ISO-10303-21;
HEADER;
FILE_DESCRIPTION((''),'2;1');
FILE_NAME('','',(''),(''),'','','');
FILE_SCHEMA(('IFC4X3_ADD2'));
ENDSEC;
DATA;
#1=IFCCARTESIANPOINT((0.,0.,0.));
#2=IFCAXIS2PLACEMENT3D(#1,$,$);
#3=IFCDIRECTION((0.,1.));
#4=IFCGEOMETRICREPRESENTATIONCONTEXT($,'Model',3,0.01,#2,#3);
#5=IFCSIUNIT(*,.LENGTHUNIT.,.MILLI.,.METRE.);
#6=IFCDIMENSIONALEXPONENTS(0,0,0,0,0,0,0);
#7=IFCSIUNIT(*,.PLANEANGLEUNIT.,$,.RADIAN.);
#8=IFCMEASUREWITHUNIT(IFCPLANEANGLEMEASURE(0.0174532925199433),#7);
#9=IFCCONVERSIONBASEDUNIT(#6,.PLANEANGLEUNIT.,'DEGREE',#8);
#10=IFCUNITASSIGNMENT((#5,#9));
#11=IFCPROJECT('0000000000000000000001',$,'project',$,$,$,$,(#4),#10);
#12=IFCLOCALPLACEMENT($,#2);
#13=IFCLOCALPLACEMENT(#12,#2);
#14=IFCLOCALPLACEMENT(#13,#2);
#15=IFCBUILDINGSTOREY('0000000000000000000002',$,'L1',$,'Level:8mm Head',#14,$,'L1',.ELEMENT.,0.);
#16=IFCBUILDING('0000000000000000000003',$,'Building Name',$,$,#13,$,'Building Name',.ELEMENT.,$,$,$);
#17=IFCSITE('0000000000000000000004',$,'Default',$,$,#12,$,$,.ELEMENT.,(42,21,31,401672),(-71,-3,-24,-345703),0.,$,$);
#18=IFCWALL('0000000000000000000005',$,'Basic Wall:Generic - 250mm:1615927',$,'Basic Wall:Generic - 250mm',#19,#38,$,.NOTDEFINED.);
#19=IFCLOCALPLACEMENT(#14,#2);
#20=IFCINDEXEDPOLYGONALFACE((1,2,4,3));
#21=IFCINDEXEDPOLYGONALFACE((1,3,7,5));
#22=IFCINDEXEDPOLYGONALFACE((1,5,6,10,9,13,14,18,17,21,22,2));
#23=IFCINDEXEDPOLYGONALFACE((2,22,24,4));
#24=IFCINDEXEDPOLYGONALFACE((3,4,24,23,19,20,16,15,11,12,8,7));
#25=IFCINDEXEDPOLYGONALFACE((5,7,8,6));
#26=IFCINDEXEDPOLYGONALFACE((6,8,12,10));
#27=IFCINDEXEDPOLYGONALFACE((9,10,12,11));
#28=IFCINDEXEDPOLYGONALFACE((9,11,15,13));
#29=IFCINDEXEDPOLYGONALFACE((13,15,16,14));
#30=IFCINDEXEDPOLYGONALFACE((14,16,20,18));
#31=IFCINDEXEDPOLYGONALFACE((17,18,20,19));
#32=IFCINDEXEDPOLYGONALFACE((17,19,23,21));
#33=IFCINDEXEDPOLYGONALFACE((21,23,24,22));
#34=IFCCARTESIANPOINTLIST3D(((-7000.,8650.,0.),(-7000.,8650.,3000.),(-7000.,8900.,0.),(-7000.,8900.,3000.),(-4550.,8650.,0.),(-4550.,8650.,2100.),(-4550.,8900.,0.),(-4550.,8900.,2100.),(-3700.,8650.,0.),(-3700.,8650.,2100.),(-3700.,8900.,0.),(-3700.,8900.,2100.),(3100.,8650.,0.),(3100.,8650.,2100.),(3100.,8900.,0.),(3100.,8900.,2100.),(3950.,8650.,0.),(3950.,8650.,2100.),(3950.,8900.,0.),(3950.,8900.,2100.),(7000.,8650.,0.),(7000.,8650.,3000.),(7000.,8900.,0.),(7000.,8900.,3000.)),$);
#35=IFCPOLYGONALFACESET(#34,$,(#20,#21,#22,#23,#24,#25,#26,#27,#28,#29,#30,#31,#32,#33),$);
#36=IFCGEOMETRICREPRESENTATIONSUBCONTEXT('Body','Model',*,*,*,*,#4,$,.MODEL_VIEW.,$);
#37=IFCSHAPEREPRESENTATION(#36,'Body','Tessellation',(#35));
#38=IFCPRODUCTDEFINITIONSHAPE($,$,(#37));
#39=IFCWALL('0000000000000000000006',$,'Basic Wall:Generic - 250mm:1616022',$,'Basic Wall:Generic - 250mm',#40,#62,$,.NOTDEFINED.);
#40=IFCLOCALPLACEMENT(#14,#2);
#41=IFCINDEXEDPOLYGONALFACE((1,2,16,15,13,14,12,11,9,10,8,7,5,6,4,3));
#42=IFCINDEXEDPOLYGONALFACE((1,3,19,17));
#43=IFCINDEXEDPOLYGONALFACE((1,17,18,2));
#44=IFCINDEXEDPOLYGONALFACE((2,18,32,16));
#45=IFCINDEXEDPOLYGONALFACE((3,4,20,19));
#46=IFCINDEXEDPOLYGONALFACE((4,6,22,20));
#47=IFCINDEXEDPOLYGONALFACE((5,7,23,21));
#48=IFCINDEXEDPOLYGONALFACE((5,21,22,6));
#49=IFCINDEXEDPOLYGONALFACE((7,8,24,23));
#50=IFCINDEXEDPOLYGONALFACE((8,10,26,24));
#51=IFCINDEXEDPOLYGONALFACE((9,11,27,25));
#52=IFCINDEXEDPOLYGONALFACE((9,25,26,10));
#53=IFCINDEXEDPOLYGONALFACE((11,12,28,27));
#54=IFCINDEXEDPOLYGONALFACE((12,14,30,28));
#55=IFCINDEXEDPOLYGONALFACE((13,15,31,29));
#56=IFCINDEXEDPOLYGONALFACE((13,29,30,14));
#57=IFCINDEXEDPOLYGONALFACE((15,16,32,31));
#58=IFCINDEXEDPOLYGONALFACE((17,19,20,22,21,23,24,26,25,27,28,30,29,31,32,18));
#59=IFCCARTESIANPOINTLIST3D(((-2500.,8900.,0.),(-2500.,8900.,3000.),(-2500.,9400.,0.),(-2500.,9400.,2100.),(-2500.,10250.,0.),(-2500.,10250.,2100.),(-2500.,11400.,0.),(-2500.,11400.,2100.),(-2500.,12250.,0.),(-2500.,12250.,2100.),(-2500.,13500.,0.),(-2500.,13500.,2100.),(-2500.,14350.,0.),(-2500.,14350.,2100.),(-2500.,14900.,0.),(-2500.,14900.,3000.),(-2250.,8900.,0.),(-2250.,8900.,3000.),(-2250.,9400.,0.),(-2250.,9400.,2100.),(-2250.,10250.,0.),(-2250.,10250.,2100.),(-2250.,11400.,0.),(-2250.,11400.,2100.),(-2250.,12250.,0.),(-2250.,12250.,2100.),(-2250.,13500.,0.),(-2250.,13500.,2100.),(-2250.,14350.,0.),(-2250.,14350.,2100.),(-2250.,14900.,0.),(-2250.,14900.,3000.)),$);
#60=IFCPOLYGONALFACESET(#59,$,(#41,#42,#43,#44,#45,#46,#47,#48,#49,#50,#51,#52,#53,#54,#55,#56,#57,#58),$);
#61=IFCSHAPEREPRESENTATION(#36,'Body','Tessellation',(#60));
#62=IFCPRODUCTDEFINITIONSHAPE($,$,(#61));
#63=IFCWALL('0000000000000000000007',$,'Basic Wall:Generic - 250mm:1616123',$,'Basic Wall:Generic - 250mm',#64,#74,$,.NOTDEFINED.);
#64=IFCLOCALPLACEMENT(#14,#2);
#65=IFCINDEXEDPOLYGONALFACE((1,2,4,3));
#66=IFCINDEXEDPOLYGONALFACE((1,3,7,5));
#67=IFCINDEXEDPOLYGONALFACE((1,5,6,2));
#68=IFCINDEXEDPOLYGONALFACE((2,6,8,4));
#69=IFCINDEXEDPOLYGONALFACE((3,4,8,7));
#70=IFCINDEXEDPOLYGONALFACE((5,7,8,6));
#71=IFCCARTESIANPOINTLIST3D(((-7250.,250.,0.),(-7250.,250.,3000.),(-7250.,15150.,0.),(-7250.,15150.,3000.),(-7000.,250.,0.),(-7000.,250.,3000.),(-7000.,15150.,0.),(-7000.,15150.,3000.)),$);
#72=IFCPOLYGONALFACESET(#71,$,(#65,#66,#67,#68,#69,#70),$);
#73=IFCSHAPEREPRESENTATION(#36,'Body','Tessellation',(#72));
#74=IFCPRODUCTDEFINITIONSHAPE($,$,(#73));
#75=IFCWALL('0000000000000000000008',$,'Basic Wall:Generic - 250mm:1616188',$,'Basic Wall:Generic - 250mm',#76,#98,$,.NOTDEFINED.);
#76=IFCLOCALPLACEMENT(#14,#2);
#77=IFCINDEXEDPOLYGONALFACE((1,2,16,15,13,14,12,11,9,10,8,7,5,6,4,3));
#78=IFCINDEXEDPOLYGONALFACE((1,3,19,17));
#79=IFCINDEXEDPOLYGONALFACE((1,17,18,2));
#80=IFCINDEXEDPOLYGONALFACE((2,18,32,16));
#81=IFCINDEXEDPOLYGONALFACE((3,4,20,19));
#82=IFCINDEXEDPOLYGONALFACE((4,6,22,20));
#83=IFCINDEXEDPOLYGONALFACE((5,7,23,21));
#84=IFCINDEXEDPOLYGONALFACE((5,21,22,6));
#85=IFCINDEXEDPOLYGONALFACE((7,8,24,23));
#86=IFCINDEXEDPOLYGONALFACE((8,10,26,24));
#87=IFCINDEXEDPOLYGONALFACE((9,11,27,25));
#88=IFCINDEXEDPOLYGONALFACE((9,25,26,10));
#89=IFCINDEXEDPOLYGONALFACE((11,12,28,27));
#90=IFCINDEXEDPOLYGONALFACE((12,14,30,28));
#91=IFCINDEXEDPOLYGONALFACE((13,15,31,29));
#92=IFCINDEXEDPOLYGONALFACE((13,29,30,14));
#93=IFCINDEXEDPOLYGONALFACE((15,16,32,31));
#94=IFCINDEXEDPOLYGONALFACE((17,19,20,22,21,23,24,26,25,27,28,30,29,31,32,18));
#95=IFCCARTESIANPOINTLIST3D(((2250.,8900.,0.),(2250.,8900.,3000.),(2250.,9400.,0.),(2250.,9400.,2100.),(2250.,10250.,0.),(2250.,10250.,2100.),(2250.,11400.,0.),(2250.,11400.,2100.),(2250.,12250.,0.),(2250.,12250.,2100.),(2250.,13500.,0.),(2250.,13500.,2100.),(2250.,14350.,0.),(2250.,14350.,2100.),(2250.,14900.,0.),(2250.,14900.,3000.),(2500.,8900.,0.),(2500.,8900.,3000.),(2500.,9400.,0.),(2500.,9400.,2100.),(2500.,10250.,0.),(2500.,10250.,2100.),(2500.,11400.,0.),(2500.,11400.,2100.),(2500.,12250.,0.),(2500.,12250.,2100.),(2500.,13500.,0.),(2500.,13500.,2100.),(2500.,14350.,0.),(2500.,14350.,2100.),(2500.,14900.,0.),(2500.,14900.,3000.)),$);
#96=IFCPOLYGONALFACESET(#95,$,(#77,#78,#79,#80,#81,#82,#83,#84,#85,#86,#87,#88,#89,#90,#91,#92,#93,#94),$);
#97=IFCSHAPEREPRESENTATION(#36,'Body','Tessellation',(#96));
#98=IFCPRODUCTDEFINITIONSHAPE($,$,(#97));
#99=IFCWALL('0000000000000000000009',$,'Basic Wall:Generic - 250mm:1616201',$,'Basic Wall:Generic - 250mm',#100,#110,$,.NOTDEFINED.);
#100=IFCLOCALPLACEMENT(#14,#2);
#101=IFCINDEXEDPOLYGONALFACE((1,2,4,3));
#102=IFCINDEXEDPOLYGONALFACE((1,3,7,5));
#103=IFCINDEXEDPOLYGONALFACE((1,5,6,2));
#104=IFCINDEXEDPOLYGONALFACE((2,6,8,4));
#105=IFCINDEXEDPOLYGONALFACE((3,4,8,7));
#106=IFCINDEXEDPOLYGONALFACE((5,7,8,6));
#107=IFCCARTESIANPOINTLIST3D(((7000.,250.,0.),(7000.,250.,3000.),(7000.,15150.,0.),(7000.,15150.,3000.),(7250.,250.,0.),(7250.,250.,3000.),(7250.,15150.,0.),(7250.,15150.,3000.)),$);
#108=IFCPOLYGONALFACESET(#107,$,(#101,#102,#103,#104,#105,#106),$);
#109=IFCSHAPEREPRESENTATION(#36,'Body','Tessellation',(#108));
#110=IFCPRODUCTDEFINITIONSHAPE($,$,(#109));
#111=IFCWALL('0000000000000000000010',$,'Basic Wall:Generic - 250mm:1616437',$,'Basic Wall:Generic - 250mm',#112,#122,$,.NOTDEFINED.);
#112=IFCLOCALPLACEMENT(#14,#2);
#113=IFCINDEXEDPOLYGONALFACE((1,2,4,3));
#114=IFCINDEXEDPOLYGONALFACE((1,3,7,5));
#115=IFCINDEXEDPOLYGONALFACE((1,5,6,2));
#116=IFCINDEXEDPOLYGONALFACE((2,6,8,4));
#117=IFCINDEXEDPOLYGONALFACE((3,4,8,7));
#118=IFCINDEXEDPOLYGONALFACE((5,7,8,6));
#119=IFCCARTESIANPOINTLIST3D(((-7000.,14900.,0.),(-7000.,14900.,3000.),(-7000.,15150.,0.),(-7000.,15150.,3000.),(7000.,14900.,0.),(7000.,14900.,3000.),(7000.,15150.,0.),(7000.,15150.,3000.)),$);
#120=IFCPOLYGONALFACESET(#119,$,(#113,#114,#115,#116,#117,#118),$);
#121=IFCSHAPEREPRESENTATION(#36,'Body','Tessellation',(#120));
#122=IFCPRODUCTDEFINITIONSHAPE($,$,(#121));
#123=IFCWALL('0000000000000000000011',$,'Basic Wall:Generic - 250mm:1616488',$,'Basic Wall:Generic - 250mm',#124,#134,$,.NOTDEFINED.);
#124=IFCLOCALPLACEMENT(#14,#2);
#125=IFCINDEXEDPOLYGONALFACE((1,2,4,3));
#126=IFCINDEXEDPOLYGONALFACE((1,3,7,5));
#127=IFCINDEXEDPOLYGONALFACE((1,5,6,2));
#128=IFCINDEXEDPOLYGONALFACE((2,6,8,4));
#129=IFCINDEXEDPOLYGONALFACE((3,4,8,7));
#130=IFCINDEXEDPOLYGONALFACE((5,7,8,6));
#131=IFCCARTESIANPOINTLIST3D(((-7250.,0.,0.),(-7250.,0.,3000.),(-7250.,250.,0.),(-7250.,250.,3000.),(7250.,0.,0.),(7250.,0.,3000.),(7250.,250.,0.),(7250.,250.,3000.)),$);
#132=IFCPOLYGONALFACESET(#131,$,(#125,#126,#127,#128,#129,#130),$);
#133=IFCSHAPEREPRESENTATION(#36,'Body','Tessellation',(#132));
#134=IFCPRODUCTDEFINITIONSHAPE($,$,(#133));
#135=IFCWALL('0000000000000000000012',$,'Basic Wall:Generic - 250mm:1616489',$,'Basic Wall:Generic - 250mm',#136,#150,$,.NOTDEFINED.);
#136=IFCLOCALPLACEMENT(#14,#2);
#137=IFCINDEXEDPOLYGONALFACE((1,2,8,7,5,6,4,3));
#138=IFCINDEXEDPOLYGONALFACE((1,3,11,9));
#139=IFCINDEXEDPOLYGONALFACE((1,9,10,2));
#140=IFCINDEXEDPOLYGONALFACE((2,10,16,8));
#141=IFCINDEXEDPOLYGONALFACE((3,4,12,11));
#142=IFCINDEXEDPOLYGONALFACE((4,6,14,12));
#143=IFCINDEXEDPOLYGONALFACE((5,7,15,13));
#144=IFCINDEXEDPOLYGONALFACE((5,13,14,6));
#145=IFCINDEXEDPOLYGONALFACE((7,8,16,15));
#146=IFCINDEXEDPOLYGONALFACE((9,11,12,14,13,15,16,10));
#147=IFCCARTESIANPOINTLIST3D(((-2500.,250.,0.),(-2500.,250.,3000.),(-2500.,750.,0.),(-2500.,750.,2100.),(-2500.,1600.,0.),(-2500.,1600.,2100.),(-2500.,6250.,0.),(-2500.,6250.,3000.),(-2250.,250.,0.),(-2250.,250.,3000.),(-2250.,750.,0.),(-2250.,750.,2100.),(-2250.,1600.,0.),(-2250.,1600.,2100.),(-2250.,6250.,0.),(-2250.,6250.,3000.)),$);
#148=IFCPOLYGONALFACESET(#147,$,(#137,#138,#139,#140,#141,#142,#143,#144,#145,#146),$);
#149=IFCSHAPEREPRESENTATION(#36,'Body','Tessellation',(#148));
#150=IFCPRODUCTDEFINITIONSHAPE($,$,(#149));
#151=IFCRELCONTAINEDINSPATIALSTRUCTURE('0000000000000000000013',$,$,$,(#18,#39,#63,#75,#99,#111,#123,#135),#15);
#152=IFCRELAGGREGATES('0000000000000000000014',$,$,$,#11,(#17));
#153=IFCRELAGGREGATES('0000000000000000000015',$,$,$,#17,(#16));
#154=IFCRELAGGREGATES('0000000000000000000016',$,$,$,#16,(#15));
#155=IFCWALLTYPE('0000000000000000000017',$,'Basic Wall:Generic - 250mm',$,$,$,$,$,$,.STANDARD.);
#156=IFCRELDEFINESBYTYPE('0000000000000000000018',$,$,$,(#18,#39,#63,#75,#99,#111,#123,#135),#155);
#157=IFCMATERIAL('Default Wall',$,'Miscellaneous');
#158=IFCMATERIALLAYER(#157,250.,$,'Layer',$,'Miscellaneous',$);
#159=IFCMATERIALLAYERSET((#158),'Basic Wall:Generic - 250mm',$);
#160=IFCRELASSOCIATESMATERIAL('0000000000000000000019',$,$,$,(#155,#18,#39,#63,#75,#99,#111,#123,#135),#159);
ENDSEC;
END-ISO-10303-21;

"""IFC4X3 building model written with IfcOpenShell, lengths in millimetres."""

from ifc_helpers import new_model, entity, si_unit, converted_unit, direction, frame, frame_2d, origin, place, context, subcontext, project, spatial, rectangle, extrude, material, layer, layer_set, type_object, element, save


model = new_model("IFC4X3")

# Units and contexts
model_context = context("Model", 3, precision=0.01, world=origin(), true_north=direction((0.0, 1.0)))
body_context = subcontext(model_context, "Body", "Model", "MODEL_VIEW")
ifc_project = project(units=[si_unit("LENGTHUNIT", "METRE", prefix="MILLI"), converted_unit("PLANEANGLEUNIT", "DEGREE", entity("IfcPlaneAngleMeasure", 0.0174532925199433), si_unit("PLANEANGLEUNIT", "RADIAN"), dimensions=[0, 0, 0, 0, 0, 0, 0])], contexts=[model_context])

# Site, building, storey
site_placement = place(None, origin())
site = spatial("IfcSite", under=ifc_project, at=site_placement, Name="Default", CompositionType="ELEMENT", RefLatitude=(42, 21, 31, 401672), RefLongitude=(-71, -3, -24, -345703), RefElevation=0.0)
building_placement = place(site_placement, origin())
building = spatial("IfcBuilding", under=site, at=building_placement, Name="Building Name", LongName="Building Name", CompositionType="ELEMENT")
storey_placement = place(building_placement, origin())
storey = spatial("IfcBuildingStorey", under=building, at=storey_placement, Name="L1", ObjectType="Level:8mm Head", LongName="L1", CompositionType="ELEMENT", Elevation=0.0)

# Walls, openings
ifc_material = material(Name="Default Wall", Category="Miscellaneous")
ifc_layer_1 = layer(ifc_material, 250.0, Name="Layer", Category="Miscellaneous")
ifc_layer_set_1 = layer_set([ifc_layer_1], Name="Basic Wall:Generic - 250mm")
wall_type_1 = type_object("IfcWallType", Name="Basic Wall:Generic - 250mm", PredefinedType="STANDARD", material=ifc_layer_set_1)
wall_1_placement = place(storey_placement, frame((-7000.0, 8775.0, 0.0)))
wall_1 = element("IfcWall", 1, at=wall_1_placement, inside=storey, type_object=wall_type_1, material=ifc_layer_set_1, Name="Basic Wall:Generic - 250mm:1615927", ObjectType="Basic Wall:Generic - 250mm", PredefinedType="NOTDEFINED", context=body_context, shape_type="SweptSolid", body=[
    extrude(rectangle(XDim=14000.0, YDim=250.0, at=frame_2d((7000.0, 0.0), x_axis=(1.0, 0.0))), origin(), (0.0, 0.0, 1.0), 3000.0),
])
opening_1_placement = place(wall_1_placement, frame((2450.0, -125.0, 0.0)))
element("IfcOpeningElement", 2, at=opening_1_placement, cuts=wall_1, PredefinedType="OPENING", context=body_context, shape_type="SweptSolid", body=[
    extrude(rectangle(XDim=2100.0, YDim=850.0, at=frame_2d((1050.0, 425.0), x_axis=(1.0, 0.0))), frame((0.0, 0.0, 0.0), z_axis=(0.0, 1.0, 0.0), x_axis=(0.0, 0.0, 1.0)), (0.0, 0.0, 1.0), 250.0),
])
opening_2_placement = place(wall_1_placement, frame((10100.0, -125.0, 0.0)))
element("IfcOpeningElement", 3, at=opening_2_placement, cuts=wall_1, PredefinedType="OPENING", context=body_context, shape_type="SweptSolid", body=[
    extrude(rectangle(XDim=2100.0, YDim=850.0, at=frame_2d((1050.0, 425.0), x_axis=(1.0, 0.0))), frame((0.0, 0.0, 0.0), z_axis=(0.0, 1.0, 0.0), x_axis=(0.0, 0.0, 1.0)), (0.0, 0.0, 1.0), 250.0),
])
wall_2_placement = place(storey_placement, frame((-2375.0, 8900.0, 0.0), z_axis=(0.0, 0.0, 1.0), x_axis=(0.0, 1.0, 0.0)))
wall_2 = element("IfcWall", 4, at=wall_2_placement, inside=storey, type_object=wall_type_1, material=ifc_layer_set_1, Name="Basic Wall:Generic - 250mm:1616022", ObjectType="Basic Wall:Generic - 250mm", PredefinedType="NOTDEFINED", context=body_context, shape_type="SweptSolid", body=[
    extrude(rectangle(XDim=6000.0, YDim=250.0, at=frame_2d((3000.0, 0.0), x_axis=(1.0, 0.0))), origin(), (0.0, 0.0, 1.0), 3000.0),
])
opening_3_placement = place(wall_2_placement, frame((1350.0, 125.0, 0.0)))
element("IfcOpeningElement", 5, at=opening_3_placement, cuts=wall_2, PredefinedType="OPENING", context=body_context, shape_type="SweptSolid", body=[
    extrude(rectangle(XDim=2100.0, YDim=850.0, at=frame_2d((1050.0, 425.0), x_axis=(1.0, 0.0))), frame((0.0, 0.0, 0.0), z_axis=(0.0, -1.0, 0.0), x_axis=(0.0, 0.0, 1.0)), (0.0, 0.0, 1.0), 250.0),
])
opening_4_placement = place(wall_2_placement, frame((3350.0, 125.0, 0.0)))
element("IfcOpeningElement", 6, at=opening_4_placement, cuts=wall_2, PredefinedType="OPENING", context=body_context, shape_type="SweptSolid", body=[
    extrude(rectangle(XDim=2100.0, YDim=850.0, at=frame_2d((1050.0, 425.0), x_axis=(1.0, 0.0))), frame((0.0, 0.0, 0.0), z_axis=(0.0, -1.0, 0.0), x_axis=(0.0, 0.0, 1.0)), (0.0, 0.0, 1.0), 250.0),
])
opening_5_placement = place(wall_2_placement, frame((5450.0, 125.0, 0.0)))
element("IfcOpeningElement", 7, at=opening_5_placement, cuts=wall_2, PredefinedType="OPENING", context=body_context, shape_type="SweptSolid", body=[
    extrude(rectangle(XDim=2100.0, YDim=850.0, at=frame_2d((1050.0, 425.0), x_axis=(1.0, 0.0))), frame((0.0, 0.0, 0.0), z_axis=(0.0, -1.0, 0.0), x_axis=(0.0, 0.0, 1.0)), (0.0, 0.0, 1.0), 250.0),
])

# Wall
wall_3_placement = place(storey_placement, frame((-7125.0, 15150.0, 0.0), z_axis=(0.0, 0.0, 1.0), x_axis=(0.0, -1.0, 0.0)))
element("IfcWall", 8, at=wall_3_placement, inside=storey, type_object=wall_type_1, material=ifc_layer_set_1, Name="Basic Wall:Generic - 250mm:1616123", ObjectType="Basic Wall:Generic - 250mm", PredefinedType="NOTDEFINED", context=body_context, shape_type="SweptSolid", body=[
    extrude(rectangle(XDim=14900.0, YDim=250.0, at=frame_2d((7450.0, 0.0), x_axis=(-1.0, 0.0))), origin(), (0.0, 0.0, 1.0), 3000.0),
])

# Wall, openings
wall_4_placement = place(storey_placement, frame((2375.0, 8900.0, 0.0), z_axis=(0.0, 0.0, 1.0), x_axis=(0.0, 1.0, 0.0)))
wall_4 = element("IfcWall", 9, at=wall_4_placement, inside=storey, type_object=wall_type_1, material=ifc_layer_set_1, Name="Basic Wall:Generic - 250mm:1616188", ObjectType="Basic Wall:Generic - 250mm", PredefinedType="NOTDEFINED", context=body_context, shape_type="SweptSolid", body=[
    extrude(rectangle(XDim=6000.0, YDim=250.0, at=frame_2d((3000.0, 0.0), x_axis=(-1.0, 0.0))), origin(), (0.0, 0.0, 1.0), 3000.0),
])
opening_6_placement = place(wall_4_placement, frame((500.0, -125.0, 0.0)))
element("IfcOpeningElement", 10, at=opening_6_placement, cuts=wall_4, PredefinedType="OPENING", context=body_context, shape_type="SweptSolid", body=[
    extrude(rectangle(XDim=2100.0, YDim=850.0, at=frame_2d((1050.0, 425.0), x_axis=(1.0, 0.0))), frame((0.0, 0.0, 0.0), z_axis=(0.0, 1.0, 0.0), x_axis=(0.0, 0.0, 1.0)), (0.0, 0.0, 1.0), 250.0),
])
opening_7_placement = place(wall_4_placement, frame((2500.0, -125.0, 0.0)))
element("IfcOpeningElement", 11, at=opening_7_placement, cuts=wall_4, PredefinedType="OPENING", context=body_context, shape_type="SweptSolid", body=[
    extrude(rectangle(XDim=2100.0, YDim=850.0, at=frame_2d((1050.0, 425.0), x_axis=(1.0, 0.0))), frame((0.0, 0.0, 0.0), z_axis=(0.0, 1.0, 0.0), x_axis=(0.0, 0.0, 1.0)), (0.0, 0.0, 1.0), 250.0),
])
opening_8_placement = place(wall_4_placement, frame((4600.0, -125.0, 0.0)))
element("IfcOpeningElement", 12, at=opening_8_placement, cuts=wall_4, PredefinedType="OPENING", context=body_context, shape_type="SweptSolid", body=[
    extrude(rectangle(XDim=2100.0, YDim=850.0, at=frame_2d((1050.0, 425.0), x_axis=(1.0, 0.0))), frame((0.0, 0.0, 0.0), z_axis=(0.0, 1.0, 0.0), x_axis=(0.0, 0.0, 1.0)), (0.0, 0.0, 1.0), 250.0),
])

# Walls
wall_5_placement = place(storey_placement, frame((7125.0, 250.0, 0.0), z_axis=(0.0, 0.0, 1.0), x_axis=(0.0, 1.0, 0.0)))
element("IfcWall", 13, at=wall_5_placement, inside=storey, type_object=wall_type_1, material=ifc_layer_set_1, Name="Basic Wall:Generic - 250mm:1616201", ObjectType="Basic Wall:Generic - 250mm", PredefinedType="NOTDEFINED", context=body_context, shape_type="SweptSolid", body=[
    extrude(rectangle(XDim=14900.0, YDim=250.0, at=frame_2d((7450.0, 0.0), x_axis=(-1.0, 0.0))), origin(), (0.0, 0.0, 1.0), 3000.0),
])
wall_6_placement = place(storey_placement, frame((-7000.0, 15025.0, 0.0)))
element("IfcWall", 14, at=wall_6_placement, inside=storey, type_object=wall_type_1, material=ifc_layer_set_1, Name="Basic Wall:Generic - 250mm:1616437", ObjectType="Basic Wall:Generic - 250mm", PredefinedType="NOTDEFINED", context=body_context, shape_type="SweptSolid", body=[
    extrude(rectangle(XDim=14000.0, YDim=250.0, at=frame_2d((7000.0, 0.0), x_axis=(-1.0, 0.0))), origin(), (0.0, 0.0, 1.0), 3000.0),
])
wall_7_placement = place(storey_placement, frame((-7250.0, 125.0, 0.0)))
element("IfcWall", 15, at=wall_7_placement, inside=storey, type_object=wall_type_1, material=ifc_layer_set_1, Name="Basic Wall:Generic - 250mm:1616488", ObjectType="Basic Wall:Generic - 250mm", PredefinedType="NOTDEFINED", context=body_context, shape_type="SweptSolid", body=[
    extrude(rectangle(XDim=14500.0, YDim=250.0, at=frame_2d((7250.0, 0.0), x_axis=(-1.0, 0.0))), origin(), (0.0, 0.0, 1.0), 3000.0),
])

# Wall, opening
wall_8_placement = place(storey_placement, frame((-2375.0, 250.0, 0.0), z_axis=(0.0, 0.0, 1.0), x_axis=(0.0, 1.0, 0.0)))
wall_8 = element("IfcWall", 16, at=wall_8_placement, inside=storey, type_object=wall_type_1, material=ifc_layer_set_1, Name="Basic Wall:Generic - 250mm:1616489", ObjectType="Basic Wall:Generic - 250mm", PredefinedType="NOTDEFINED", context=body_context, shape_type="SweptSolid", body=[
    extrude(rectangle(XDim=6000.0, YDim=250.0, at=frame_2d((3000.0, 0.0), x_axis=(1.0, 0.0))), origin(), (0.0, 0.0, 1.0), 3000.0),
])
opening_9_placement = place(wall_8_placement, frame((1350.0, 125.0, 0.0)))
element("IfcOpeningElement", 17, at=opening_9_placement, cuts=wall_8, PredefinedType="OPENING", context=body_context, shape_type="SweptSolid", body=[
    extrude(rectangle(XDim=2100.0, YDim=850.0, at=frame_2d((1050.0, 425.0), x_axis=(1.0, 0.0))), frame((0.0, 0.0, 0.0), z_axis=(0.0, -1.0, 0.0), x_axis=(0.0, 0.0, 1.0)), (0.0, 0.0, 1.0), 250.0),
])

save(model, "model.ifc")
